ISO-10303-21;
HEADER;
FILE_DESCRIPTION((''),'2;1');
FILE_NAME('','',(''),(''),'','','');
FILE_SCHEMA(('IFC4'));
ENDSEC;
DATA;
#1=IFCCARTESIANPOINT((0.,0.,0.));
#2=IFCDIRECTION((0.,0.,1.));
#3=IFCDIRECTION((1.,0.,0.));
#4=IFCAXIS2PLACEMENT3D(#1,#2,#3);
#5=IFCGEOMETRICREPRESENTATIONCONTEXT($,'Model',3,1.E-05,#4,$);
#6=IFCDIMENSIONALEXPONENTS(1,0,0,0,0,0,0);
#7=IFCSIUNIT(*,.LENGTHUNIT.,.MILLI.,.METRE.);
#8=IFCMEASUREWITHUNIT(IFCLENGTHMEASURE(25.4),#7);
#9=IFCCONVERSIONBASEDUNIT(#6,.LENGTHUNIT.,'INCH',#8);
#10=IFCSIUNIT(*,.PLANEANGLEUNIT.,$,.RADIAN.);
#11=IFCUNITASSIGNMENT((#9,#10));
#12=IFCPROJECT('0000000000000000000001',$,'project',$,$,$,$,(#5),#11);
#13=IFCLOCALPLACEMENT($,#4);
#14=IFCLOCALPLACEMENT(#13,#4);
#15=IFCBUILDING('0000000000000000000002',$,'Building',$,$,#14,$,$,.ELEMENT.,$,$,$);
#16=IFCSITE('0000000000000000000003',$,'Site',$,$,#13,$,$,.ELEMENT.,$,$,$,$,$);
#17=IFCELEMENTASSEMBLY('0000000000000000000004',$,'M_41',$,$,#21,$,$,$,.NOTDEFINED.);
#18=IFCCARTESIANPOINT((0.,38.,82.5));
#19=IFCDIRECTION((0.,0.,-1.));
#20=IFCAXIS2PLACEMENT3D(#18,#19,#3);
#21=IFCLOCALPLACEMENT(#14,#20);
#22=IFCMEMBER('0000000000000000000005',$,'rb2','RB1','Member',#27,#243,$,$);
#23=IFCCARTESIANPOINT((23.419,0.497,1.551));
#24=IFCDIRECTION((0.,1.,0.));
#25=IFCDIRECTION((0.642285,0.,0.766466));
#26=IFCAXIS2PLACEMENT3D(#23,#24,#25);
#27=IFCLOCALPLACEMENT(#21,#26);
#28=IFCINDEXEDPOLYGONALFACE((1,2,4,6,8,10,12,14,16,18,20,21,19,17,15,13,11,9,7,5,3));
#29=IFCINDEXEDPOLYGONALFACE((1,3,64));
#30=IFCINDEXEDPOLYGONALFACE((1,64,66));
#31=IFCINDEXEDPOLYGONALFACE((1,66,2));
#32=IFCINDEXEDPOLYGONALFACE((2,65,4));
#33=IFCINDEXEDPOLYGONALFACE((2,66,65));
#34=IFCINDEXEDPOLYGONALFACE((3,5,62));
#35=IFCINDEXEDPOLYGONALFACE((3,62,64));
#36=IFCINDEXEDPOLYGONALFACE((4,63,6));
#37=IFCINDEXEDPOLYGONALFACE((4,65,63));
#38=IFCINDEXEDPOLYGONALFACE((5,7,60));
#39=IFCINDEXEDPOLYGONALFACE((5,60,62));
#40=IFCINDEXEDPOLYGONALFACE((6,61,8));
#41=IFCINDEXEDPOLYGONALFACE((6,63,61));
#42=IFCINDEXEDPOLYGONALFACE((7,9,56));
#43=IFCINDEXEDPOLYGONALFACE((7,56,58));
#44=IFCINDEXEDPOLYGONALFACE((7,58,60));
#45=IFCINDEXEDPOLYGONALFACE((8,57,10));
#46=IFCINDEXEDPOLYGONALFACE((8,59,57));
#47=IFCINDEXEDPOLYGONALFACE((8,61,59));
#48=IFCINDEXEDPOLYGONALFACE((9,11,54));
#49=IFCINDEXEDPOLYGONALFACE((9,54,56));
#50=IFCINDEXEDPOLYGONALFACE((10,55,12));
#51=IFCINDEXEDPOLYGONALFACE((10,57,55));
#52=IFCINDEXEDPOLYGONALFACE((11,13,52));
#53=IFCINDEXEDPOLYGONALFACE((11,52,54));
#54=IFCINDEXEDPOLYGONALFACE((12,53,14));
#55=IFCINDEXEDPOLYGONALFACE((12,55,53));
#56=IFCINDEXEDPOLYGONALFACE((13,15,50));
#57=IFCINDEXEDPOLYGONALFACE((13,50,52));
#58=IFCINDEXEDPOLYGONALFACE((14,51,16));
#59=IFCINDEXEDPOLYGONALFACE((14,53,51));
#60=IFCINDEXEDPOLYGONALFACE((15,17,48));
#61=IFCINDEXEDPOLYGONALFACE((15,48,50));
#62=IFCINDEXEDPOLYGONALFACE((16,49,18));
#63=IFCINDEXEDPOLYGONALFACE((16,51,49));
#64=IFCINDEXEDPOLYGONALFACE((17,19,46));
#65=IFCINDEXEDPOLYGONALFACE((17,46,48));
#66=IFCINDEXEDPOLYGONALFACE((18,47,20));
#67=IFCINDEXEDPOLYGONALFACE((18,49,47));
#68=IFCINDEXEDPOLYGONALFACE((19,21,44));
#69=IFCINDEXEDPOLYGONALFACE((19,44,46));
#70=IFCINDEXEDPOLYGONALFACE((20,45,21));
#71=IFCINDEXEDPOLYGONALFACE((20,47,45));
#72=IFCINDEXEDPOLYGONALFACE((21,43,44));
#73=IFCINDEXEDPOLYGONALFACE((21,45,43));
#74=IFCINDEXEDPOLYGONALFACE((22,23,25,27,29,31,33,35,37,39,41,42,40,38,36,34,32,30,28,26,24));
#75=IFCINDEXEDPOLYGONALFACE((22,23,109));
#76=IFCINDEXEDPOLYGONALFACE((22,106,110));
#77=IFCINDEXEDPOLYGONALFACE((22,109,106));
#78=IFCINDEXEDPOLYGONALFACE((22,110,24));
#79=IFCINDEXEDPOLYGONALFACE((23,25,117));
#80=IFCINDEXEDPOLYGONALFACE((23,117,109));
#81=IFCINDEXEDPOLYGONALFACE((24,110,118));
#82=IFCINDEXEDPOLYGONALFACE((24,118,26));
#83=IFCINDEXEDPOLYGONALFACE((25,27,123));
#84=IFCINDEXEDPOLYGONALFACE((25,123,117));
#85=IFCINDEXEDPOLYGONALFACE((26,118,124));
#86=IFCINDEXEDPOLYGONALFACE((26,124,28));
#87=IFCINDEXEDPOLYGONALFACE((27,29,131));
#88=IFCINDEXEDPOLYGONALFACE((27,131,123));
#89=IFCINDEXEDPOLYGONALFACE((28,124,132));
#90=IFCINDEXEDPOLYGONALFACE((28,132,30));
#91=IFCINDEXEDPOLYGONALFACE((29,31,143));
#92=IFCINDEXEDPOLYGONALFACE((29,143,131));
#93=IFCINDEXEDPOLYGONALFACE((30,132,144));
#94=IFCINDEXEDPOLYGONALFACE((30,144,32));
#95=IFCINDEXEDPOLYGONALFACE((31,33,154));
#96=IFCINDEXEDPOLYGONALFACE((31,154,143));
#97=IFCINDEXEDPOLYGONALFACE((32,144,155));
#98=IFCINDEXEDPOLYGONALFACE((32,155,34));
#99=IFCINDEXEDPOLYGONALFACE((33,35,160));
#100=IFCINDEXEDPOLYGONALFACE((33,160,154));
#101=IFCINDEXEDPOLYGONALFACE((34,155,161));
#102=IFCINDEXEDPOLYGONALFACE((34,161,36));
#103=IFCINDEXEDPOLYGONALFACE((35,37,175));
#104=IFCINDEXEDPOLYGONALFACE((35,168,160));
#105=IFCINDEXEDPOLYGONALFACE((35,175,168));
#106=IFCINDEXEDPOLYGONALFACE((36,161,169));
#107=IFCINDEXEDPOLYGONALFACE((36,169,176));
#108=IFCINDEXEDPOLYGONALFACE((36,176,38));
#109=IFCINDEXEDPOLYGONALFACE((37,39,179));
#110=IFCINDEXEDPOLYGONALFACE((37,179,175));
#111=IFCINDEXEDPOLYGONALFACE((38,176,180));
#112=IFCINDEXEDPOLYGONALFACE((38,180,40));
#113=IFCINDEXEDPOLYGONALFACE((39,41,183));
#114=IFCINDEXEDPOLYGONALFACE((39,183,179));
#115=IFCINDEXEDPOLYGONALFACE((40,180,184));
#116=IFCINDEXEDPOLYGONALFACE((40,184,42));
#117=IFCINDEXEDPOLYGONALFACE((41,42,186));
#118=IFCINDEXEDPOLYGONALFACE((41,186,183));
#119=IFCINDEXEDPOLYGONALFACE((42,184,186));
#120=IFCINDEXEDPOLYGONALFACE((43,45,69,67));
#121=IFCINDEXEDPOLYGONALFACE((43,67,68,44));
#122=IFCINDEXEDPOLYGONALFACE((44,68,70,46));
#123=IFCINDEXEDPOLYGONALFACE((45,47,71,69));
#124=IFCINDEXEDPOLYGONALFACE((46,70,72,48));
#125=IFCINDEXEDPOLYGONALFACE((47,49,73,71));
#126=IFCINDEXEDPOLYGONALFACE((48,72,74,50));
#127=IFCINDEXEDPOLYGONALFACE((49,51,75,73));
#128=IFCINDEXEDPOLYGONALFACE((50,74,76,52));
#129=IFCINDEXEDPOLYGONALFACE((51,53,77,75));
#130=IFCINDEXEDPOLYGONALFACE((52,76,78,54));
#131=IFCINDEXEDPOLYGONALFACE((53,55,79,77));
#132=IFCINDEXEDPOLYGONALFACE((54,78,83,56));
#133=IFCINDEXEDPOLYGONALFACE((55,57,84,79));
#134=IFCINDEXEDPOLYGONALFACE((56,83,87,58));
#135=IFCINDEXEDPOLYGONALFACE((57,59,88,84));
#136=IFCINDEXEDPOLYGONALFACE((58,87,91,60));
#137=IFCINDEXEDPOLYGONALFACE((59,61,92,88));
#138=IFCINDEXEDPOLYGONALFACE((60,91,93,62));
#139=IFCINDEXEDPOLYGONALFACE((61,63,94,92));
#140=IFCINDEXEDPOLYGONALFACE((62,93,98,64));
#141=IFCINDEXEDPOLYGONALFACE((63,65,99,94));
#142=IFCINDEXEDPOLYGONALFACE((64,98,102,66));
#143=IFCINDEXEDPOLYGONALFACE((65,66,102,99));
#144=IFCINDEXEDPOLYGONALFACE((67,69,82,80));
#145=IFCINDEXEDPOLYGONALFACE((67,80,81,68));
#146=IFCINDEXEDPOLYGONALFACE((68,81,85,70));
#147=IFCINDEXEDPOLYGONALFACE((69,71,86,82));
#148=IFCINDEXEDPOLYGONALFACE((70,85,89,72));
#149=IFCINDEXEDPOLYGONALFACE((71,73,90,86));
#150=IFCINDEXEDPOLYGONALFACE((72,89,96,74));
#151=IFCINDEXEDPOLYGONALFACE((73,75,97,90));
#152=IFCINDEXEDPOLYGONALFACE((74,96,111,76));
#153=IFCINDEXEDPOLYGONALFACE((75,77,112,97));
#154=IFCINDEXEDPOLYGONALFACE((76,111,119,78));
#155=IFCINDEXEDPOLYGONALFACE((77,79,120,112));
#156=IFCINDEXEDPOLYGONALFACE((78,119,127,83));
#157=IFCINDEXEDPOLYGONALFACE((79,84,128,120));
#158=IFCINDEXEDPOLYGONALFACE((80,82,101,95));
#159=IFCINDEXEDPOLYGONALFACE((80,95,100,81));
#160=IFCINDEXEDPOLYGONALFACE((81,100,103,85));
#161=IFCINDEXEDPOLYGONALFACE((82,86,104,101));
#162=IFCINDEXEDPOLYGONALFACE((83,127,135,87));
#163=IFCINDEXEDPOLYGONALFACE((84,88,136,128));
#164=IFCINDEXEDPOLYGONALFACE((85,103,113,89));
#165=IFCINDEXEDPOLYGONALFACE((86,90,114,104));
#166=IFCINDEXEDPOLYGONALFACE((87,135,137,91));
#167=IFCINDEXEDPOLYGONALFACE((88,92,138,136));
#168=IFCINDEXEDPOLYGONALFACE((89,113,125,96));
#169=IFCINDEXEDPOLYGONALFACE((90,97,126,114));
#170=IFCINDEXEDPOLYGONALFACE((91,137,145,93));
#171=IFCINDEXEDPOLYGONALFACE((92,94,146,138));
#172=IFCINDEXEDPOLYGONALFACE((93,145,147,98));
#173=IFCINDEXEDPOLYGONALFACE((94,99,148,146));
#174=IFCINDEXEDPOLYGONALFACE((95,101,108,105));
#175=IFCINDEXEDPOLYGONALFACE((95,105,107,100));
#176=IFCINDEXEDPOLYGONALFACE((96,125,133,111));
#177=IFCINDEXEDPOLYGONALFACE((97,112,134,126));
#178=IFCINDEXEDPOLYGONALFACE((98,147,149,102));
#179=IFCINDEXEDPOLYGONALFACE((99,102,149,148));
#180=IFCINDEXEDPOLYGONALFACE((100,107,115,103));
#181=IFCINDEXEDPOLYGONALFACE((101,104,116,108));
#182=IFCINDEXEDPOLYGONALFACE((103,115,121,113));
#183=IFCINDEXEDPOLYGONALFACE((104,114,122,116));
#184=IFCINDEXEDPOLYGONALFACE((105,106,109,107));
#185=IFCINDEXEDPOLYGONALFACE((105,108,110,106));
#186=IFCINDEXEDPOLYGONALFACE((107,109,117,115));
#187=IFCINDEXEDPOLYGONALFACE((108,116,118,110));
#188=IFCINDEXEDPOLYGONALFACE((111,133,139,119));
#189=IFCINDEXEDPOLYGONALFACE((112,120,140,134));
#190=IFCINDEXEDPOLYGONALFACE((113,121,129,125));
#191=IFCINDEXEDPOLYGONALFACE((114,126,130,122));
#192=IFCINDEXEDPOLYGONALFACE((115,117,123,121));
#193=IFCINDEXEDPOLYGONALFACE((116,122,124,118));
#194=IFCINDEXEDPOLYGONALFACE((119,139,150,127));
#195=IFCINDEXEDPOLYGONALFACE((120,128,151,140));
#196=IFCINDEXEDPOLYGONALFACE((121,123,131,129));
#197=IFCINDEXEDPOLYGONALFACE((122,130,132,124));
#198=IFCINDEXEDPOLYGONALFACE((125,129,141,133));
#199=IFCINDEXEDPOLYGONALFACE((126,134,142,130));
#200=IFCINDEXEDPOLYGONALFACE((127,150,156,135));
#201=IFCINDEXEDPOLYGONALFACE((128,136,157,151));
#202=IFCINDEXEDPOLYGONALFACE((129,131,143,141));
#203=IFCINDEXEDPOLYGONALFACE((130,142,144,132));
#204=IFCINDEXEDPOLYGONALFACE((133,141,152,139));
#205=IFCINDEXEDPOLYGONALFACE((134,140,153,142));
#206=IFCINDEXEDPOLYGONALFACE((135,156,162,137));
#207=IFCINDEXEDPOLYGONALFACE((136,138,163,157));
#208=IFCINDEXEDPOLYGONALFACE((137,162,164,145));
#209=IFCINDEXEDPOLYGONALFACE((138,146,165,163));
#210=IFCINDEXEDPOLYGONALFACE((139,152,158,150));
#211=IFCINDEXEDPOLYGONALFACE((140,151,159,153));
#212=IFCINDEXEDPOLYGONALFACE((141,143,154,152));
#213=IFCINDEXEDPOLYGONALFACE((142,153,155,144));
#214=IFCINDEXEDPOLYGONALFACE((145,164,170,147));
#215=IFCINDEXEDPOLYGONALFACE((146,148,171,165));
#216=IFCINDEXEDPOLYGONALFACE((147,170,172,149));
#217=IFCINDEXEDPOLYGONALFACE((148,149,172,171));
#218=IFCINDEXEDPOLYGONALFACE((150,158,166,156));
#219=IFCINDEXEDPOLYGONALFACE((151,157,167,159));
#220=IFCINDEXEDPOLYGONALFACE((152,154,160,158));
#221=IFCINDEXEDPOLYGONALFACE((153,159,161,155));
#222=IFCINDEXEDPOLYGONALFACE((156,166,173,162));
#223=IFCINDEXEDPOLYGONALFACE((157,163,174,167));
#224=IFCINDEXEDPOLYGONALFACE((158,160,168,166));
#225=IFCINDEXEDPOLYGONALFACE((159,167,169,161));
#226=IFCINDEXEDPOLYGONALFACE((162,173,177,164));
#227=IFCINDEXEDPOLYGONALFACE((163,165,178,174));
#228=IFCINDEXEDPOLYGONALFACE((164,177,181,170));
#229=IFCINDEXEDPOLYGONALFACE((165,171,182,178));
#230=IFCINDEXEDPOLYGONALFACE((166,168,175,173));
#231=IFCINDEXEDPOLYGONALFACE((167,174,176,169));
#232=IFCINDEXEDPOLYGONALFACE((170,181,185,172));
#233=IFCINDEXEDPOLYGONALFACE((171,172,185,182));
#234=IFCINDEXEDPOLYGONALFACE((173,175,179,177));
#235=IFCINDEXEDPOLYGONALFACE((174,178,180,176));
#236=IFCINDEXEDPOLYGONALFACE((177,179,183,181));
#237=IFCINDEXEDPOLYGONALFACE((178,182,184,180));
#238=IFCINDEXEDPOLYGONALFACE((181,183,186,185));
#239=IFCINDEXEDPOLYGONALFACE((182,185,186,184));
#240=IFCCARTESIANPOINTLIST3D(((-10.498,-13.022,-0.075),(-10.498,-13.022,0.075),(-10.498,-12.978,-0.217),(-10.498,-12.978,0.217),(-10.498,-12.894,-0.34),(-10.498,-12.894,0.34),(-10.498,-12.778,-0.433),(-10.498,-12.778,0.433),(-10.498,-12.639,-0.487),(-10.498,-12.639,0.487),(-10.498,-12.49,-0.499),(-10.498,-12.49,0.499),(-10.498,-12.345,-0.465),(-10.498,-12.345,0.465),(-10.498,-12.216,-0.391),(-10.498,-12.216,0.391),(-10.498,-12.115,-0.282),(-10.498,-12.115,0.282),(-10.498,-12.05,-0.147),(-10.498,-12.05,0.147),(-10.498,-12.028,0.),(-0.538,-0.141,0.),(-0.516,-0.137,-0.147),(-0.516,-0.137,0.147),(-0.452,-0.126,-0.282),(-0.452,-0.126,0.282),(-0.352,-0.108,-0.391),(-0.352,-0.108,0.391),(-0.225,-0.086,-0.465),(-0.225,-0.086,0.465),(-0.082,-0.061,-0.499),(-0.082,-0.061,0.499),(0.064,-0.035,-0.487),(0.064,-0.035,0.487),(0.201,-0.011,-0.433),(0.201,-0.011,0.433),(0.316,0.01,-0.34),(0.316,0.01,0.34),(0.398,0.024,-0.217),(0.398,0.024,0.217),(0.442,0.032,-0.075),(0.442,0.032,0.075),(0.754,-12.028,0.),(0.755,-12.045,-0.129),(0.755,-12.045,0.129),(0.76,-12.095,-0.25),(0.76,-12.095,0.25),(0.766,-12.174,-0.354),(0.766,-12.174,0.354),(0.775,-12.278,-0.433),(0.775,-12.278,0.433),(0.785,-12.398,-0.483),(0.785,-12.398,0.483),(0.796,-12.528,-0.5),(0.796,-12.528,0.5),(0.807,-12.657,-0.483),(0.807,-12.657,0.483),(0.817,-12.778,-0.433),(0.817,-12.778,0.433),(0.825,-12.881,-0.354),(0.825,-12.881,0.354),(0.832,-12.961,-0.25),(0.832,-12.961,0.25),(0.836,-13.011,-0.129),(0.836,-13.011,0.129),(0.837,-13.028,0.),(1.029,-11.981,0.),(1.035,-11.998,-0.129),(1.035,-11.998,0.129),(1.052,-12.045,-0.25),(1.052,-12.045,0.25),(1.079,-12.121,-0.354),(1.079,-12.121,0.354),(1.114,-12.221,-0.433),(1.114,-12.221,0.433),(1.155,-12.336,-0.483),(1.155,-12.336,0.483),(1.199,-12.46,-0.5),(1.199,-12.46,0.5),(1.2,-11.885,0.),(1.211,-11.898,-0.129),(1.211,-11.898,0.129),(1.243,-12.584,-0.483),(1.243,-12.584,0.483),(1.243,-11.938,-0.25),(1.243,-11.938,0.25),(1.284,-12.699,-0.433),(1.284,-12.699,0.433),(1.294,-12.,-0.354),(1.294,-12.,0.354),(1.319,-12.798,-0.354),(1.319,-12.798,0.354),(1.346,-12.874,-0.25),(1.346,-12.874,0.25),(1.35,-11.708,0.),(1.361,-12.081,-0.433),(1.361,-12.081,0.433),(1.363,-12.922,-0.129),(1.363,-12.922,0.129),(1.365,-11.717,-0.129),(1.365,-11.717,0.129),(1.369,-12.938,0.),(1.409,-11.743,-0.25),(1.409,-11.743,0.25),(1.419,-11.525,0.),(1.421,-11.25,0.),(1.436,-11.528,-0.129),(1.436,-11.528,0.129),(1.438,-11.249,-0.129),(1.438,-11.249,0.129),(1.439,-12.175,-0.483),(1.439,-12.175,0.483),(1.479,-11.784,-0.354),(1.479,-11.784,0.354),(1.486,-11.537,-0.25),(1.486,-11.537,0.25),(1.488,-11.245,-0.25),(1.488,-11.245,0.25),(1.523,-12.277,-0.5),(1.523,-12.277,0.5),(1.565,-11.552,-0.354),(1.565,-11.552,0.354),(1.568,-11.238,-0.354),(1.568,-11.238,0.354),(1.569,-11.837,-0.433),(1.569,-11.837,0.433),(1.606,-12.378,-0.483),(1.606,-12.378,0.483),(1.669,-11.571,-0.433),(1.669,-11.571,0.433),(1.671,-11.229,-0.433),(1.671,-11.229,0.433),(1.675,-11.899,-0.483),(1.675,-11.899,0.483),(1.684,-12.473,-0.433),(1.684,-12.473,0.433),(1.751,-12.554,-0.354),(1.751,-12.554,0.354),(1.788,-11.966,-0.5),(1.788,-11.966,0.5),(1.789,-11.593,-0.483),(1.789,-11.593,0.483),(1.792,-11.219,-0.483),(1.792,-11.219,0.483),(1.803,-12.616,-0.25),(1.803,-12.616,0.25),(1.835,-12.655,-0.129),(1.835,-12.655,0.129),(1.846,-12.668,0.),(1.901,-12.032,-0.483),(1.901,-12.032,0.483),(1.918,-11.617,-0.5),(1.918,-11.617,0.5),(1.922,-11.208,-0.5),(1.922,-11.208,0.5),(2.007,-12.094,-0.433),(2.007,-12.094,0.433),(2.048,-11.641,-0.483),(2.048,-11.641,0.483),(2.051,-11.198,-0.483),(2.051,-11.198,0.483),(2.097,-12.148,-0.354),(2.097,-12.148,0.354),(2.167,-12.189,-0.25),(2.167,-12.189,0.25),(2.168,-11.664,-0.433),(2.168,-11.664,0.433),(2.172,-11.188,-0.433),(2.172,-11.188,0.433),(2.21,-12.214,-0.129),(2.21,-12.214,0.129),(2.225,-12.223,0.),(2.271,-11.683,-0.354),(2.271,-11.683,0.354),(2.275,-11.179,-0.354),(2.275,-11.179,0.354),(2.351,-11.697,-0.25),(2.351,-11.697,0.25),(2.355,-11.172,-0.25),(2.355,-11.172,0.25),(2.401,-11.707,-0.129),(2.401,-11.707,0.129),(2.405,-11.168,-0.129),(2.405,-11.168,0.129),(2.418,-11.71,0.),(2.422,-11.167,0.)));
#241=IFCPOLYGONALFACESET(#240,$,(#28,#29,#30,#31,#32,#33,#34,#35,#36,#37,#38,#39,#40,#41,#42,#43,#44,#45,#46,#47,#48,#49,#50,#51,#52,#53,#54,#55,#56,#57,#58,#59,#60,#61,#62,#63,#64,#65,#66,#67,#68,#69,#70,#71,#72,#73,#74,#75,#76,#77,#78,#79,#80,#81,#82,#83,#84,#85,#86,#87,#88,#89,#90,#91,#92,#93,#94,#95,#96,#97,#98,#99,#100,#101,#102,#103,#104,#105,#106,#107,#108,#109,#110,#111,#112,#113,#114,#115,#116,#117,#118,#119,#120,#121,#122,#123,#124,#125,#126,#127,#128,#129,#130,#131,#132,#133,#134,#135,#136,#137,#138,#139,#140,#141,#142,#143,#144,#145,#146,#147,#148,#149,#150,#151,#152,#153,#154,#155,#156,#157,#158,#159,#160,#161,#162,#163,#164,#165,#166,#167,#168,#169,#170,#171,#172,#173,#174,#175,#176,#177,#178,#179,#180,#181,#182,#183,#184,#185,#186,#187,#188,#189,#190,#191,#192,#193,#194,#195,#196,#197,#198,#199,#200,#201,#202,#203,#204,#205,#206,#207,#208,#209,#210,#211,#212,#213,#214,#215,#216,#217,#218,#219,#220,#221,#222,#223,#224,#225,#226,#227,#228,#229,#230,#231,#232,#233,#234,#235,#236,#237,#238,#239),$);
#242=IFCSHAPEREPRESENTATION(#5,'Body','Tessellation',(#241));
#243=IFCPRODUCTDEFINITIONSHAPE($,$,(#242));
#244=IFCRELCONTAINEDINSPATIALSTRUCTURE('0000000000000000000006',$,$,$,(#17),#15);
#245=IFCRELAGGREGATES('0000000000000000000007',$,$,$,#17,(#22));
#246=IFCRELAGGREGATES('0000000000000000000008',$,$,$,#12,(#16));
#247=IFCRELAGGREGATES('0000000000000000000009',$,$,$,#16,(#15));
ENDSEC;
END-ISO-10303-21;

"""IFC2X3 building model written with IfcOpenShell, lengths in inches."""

from ifc_helpers import new_model, entity, si_unit, converted_unit, frame, origin_with_axes, place, context, project, spatial, element, aggregate, save


model = new_model("IFC2X3")

# Units and contexts
model_context = context("Model", 3, precision=1e-05, world=origin_with_axes())
ifc_project = project(units=[converted_unit("LENGTHUNIT", "INCH", entity("IfcLengthMeasure", 25.4), si_unit("LENGTHUNIT", "METRE", prefix="MILLI"), dimensions=[1, 0, 0, 0, 0, 0, 0]), si_unit("PLANEANGLEUNIT", "RADIAN")], contexts=[model_context])

# Site, building
site_placement = place(None, origin_with_axes())
site = spatial("IfcSite", under=ifc_project, at=site_placement, Name="Site", CompositionType="ELEMENT")
building_placement = place(site_placement, origin_with_axes())
building = spatial("IfcBuilding", under=site, at=building_placement, Name="Building", CompositionType="ELEMENT")

# Element assembly
assembly_1_placement = place(building_placement, frame((0.0, 38.0, 82.5), z_axis=(0.0, 0.0, -1.0), x_axis=(1.0, 0.0, 0.0)))
assembly_1 = element("IfcElementAssembly", 1, at=assembly_1_placement, inside=building, Name="M_41", PredefinedType="NOTDEFINED")

# Member
member_1_placement = place(assembly_1_placement, frame((23.419, 0.497, 1.551), z_axis=(0.0, 1.0, 0.0), x_axis=(0.642285, 0.0, 0.766466)))
cartesian_point_1 = entity("IfcCartesianPoint", [0.0, 0.0, 0.0])
ifc_direction_1 = entity("IfcDirection", [0.0, 0.0, 1.0])
member_1 = element("IfcMember", 2, at=member_1_placement, Name="rb2", Description="RB1", ObjectType="Member", context=model_context, shape_type="SweptSolid", body=[
    entity("IfcSurfaceCurveSweptAreaSolid", entity("IfcCircleProfileDef", "AREA", None, entity("IfcAxis2Placement2D", entity("IfcCartesianPoint", [0.0, 0.0]), entity("IfcDirection", [1.0, 0.0])), 0.5), entity("IfcAxis2Placement3D", cartesian_point_1, ifc_direction_1, entity("IfcDirection", [1.0, 0.0, 0.0])), entity("IfcPolyline", [entity("IfcCartesianPoint", [-0.045, -0.054]), entity("IfcCartesianPoint", [1.921, -11.208]), entity("IfcCartesianPoint", [1.918, -11.617]), entity("IfcCartesianPoint", [1.788, -11.966]), entity("IfcCartesianPoint", [1.523, -12.277]), entity("IfcCartesianPoint", [1.199, -12.46]), entity("IfcCartesianPoint", [0.796, -12.528]), entity("IfcCartesianPoint", [-10.498, -12.528])]), 0.0, 1.0, entity("IfcPlane", entity("IfcAxis2Placement3D", cartesian_point_1, entity("IfcDirection", [0.0, 1.0, 0.0]), ifc_direction_1))),
])

aggregate(assembly_1, [member_1])

save(model, "model.ifc")
